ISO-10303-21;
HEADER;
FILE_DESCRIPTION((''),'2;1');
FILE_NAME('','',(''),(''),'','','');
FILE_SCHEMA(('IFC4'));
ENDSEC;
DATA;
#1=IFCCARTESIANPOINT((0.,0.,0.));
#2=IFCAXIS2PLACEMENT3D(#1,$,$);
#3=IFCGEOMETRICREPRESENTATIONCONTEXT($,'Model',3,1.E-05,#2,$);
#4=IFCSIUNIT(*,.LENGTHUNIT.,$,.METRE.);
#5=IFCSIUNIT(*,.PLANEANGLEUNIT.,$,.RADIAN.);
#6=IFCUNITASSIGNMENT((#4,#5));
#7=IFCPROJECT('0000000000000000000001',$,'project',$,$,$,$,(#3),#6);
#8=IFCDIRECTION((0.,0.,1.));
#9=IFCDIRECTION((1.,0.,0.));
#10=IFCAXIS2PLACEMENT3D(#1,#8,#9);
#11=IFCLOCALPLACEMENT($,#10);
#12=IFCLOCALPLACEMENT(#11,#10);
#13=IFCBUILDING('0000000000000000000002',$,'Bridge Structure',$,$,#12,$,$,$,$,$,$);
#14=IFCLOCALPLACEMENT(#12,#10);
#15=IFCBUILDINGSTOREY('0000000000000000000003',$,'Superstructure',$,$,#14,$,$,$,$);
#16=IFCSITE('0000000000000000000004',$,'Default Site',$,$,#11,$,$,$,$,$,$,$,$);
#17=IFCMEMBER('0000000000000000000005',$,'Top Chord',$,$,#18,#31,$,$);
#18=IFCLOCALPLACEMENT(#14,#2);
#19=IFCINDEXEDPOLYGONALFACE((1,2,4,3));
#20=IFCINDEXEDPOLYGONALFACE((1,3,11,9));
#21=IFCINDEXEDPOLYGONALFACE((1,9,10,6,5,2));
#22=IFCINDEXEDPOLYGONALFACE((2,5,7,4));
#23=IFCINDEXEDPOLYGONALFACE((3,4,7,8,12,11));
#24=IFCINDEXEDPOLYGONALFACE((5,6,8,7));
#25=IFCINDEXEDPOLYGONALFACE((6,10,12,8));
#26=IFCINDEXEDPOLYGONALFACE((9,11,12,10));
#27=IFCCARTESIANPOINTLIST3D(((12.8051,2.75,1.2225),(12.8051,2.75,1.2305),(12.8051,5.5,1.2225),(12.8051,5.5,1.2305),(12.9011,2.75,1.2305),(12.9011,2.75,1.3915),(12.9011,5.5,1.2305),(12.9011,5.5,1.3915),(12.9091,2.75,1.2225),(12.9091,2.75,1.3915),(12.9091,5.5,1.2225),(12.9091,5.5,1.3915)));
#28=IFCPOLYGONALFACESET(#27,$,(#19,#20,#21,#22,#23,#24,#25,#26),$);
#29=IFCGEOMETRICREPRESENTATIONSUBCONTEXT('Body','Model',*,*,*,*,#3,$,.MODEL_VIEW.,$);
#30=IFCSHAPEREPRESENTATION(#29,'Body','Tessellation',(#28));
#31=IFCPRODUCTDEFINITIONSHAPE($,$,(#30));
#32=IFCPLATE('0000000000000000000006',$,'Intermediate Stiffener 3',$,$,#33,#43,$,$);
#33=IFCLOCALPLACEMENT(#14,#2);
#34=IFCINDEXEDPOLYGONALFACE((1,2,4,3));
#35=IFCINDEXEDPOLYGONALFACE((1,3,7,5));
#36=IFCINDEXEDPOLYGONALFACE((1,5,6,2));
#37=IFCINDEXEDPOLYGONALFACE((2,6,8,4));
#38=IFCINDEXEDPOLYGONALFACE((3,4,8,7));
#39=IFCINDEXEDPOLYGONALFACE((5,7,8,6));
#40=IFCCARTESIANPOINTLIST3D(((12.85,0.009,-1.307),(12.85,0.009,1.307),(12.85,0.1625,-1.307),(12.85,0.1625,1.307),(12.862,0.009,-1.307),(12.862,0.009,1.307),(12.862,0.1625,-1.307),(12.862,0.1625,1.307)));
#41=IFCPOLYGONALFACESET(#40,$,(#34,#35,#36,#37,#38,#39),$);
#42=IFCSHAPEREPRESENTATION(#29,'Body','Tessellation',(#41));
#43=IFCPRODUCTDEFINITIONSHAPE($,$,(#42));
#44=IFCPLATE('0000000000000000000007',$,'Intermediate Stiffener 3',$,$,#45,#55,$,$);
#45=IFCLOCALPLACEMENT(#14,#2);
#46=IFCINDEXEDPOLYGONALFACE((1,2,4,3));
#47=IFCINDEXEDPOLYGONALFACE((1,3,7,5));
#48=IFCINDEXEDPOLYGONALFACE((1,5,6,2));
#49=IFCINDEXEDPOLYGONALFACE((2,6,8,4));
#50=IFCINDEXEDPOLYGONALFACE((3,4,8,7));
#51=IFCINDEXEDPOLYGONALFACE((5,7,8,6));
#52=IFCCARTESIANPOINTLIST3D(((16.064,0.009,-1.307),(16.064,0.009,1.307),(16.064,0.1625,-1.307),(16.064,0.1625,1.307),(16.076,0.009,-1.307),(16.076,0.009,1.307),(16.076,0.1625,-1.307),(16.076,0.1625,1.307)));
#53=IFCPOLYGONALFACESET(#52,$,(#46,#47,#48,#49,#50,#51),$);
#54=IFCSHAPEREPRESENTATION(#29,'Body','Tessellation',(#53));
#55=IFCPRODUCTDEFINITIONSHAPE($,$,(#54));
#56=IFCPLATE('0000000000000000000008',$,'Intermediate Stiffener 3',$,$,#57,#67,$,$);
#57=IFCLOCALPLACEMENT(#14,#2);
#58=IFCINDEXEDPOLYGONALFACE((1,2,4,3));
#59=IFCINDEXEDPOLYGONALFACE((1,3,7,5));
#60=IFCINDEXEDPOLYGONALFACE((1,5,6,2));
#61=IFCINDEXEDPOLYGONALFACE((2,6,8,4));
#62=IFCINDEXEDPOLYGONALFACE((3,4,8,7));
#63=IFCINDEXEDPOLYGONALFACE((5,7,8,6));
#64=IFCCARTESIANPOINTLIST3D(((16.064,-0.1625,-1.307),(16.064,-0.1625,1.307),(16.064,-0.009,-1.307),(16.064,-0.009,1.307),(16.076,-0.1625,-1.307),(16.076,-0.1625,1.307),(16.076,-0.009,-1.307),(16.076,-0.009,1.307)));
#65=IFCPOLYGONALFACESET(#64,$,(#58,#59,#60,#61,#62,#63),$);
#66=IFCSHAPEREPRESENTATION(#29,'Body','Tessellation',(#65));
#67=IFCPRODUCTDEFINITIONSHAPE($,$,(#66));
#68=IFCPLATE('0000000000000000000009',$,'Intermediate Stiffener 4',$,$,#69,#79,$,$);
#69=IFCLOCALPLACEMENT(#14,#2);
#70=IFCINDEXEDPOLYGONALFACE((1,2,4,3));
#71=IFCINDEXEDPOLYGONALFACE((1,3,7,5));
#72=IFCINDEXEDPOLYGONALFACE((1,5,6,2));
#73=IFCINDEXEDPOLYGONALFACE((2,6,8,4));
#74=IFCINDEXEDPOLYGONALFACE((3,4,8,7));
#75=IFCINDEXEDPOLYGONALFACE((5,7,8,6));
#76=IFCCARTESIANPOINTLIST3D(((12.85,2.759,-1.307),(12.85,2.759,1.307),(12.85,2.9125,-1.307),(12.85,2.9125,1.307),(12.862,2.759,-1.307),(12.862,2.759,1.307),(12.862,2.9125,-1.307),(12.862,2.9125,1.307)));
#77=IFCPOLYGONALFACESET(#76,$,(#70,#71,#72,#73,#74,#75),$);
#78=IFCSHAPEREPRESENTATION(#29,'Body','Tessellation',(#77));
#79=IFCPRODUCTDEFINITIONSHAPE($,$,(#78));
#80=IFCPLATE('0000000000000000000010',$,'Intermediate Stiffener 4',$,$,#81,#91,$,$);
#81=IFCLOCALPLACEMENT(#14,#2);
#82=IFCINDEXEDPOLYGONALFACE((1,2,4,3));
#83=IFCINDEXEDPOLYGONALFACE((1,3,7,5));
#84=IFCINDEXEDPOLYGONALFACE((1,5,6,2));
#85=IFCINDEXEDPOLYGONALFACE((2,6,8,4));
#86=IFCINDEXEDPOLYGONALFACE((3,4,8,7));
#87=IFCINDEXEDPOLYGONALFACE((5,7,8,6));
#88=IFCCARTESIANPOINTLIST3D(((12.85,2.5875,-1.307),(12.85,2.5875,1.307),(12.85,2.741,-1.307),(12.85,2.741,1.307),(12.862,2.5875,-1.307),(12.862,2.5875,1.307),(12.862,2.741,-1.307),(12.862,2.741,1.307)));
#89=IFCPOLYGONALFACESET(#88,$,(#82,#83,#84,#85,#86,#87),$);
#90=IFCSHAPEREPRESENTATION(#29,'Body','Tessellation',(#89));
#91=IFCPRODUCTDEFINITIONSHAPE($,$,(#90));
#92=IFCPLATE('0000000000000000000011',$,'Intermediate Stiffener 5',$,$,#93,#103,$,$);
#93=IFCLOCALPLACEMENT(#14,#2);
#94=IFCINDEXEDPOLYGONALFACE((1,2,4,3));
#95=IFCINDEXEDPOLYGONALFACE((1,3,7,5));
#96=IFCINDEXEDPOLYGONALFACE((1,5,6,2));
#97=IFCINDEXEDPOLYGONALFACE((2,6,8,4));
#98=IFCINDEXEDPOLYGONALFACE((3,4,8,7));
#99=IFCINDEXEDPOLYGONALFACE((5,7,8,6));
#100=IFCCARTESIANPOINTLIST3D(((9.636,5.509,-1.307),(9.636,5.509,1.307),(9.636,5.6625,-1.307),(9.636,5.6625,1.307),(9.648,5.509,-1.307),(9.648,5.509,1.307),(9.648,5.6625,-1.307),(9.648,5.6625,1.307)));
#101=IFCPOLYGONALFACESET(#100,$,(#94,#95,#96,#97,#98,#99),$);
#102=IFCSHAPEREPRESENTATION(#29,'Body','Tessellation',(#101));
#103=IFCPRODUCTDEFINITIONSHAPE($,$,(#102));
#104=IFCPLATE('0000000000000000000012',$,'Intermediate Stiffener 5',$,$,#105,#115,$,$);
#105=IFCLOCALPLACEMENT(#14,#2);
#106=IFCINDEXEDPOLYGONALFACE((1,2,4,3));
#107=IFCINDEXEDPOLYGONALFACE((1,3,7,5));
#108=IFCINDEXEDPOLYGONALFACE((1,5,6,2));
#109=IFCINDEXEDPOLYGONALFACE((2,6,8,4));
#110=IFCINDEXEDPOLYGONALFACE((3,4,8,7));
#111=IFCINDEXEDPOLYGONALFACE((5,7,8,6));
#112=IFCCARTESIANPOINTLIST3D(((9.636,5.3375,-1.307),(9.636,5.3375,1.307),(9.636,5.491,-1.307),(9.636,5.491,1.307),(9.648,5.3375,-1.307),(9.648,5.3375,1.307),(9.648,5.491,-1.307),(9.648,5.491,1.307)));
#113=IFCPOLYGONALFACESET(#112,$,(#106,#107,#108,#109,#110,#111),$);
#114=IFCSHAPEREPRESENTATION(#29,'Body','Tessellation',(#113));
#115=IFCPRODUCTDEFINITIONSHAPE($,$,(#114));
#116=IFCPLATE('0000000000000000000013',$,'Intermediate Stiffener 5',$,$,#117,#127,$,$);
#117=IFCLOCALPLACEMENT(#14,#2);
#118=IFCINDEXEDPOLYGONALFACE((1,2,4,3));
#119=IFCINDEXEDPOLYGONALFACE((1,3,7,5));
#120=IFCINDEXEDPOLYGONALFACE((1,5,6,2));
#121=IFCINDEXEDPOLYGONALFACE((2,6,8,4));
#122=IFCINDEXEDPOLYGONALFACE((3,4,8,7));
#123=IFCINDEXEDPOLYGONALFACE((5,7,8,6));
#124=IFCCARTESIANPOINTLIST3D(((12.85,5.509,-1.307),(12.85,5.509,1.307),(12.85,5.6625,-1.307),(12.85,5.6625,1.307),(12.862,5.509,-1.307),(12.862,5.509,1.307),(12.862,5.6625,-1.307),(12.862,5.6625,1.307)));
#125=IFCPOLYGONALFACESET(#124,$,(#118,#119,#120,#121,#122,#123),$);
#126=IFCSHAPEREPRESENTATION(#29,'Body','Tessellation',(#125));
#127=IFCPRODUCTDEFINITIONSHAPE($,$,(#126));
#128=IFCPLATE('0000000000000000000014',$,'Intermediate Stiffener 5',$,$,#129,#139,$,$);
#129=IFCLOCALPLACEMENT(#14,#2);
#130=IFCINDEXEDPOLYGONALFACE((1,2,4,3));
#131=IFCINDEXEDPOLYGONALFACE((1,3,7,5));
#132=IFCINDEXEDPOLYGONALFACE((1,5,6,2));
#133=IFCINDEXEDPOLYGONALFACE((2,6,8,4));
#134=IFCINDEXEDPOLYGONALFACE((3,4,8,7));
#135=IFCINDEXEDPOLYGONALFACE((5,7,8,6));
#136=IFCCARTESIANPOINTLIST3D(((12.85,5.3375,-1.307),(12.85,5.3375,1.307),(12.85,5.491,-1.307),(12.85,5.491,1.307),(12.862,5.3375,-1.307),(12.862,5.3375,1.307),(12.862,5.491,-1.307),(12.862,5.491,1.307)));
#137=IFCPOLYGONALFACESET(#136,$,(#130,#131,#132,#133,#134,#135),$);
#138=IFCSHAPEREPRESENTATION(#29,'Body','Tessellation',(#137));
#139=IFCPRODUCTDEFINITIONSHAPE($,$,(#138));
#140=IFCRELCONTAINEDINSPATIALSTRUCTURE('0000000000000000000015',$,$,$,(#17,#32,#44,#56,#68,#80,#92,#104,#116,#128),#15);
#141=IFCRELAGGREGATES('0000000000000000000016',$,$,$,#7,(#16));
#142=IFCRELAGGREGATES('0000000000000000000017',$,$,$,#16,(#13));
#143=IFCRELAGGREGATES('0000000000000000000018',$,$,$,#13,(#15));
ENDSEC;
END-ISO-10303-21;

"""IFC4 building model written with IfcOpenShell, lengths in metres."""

from ifc_helpers import new_model, si_unit, frame, origin, origin_with_axes, origin_2d_with_axis, place, context, subcontext, project, spatial, rectangle, l_section, extrude, element, save


model = new_model("IFC4")

# Units and contexts
model_context = context("Model", 3, precision=1e-05, world=origin())
body_context = subcontext(model_context, "Body", "Model", "MODEL_VIEW")
ifc_project = project(units=[si_unit("LENGTHUNIT", "METRE"), si_unit("PLANEANGLEUNIT", "RADIAN")], contexts=[model_context])

# Site, building, storey
site_placement = place(None, origin_with_axes())
site = spatial("IfcSite", under=ifc_project, at=site_placement, Name="Default Site")
building_placement = place(site_placement, origin_with_axes())
building = spatial("IfcBuilding", under=site, at=building_placement, Name="Bridge Structure")
storey_placement = place(building_placement, origin_with_axes())
storey = spatial("IfcBuildingStorey", under=building, at=storey_placement, Name="Superstructure")

# Member
for number, where, z_axis, x_axis, name in (
    (1, (12.8571, 2.75, 1.307), (0.0, 1.0, 0.0), (-1.0, 0.0, 0.0), "Top Chord"),
):
    element("IfcMember", number, at=place(storey_placement, frame(where, z_axis=z_axis, x_axis=x_axis)), inside=storey, Name=name, context=body_context, shape_type="SweptSolid", body=[
        extrude(l_section(Depth=0.169, Width=0.104, Thickness=0.008, at=origin_2d_with_axis()), origin_with_axes(), (0.0, 0.0, 1.0), 2.75),
    ])

# Plates
for number, where, z_axis, x_axis, name in (
    (2, (12.856, 0.0858, -1.307), (0.0, 0.0, 1.0), (1.0, 0.0, 0.0), "Intermediate Stiffener 3"),
    (3, (16.07, 0.0858, -1.307), (0.0, 0.0, 1.0), (1.0, 0.0, 0.0), "Intermediate Stiffener 3"),
    (4, (16.07, -0.0858, -1.307), (0.0, 0.0, 1.0), (1.0, 0.0, 0.0), "Intermediate Stiffener 3"),
    (5, (12.856, 2.8357, -1.307), (0.0, 0.0, 1.0), (1.0, 0.0, 0.0), "Intermediate Stiffener 4"),
    (6, (12.856, 2.6643, -1.307), (0.0, 0.0, 1.0), (1.0, 0.0, 0.0), "Intermediate Stiffener 4"),
    (7, (9.642, 5.5857, -1.307), (0.0, 0.0, 1.0), (1.0, 0.0, 0.0), "Intermediate Stiffener 5"),
    (8, (9.642, 5.4143, -1.307), (0.0, 0.0, 1.0), (1.0, 0.0, 0.0), "Intermediate Stiffener 5"),
    (9, (12.856, 5.5857, -1.307), (0.0, 0.0, 1.0), (1.0, 0.0, 0.0), "Intermediate Stiffener 5"),
    (10, (12.856, 5.4143, -1.307), (0.0, 0.0, 1.0), (1.0, 0.0, 0.0), "Intermediate Stiffener 5"),
):
    element("IfcPlate", number, at=place(storey_placement, frame(where, z_axis=z_axis, x_axis=x_axis)), inside=storey, Name=name, context=body_context, shape_type="SweptSolid", body=[
        extrude(rectangle(XDim=0.012, YDim=0.1535, at=origin_2d_with_axis()), origin_with_axes(), (0.0, 0.0, 1.0), 2.614),
    ])

save(model, "model.ifc")
